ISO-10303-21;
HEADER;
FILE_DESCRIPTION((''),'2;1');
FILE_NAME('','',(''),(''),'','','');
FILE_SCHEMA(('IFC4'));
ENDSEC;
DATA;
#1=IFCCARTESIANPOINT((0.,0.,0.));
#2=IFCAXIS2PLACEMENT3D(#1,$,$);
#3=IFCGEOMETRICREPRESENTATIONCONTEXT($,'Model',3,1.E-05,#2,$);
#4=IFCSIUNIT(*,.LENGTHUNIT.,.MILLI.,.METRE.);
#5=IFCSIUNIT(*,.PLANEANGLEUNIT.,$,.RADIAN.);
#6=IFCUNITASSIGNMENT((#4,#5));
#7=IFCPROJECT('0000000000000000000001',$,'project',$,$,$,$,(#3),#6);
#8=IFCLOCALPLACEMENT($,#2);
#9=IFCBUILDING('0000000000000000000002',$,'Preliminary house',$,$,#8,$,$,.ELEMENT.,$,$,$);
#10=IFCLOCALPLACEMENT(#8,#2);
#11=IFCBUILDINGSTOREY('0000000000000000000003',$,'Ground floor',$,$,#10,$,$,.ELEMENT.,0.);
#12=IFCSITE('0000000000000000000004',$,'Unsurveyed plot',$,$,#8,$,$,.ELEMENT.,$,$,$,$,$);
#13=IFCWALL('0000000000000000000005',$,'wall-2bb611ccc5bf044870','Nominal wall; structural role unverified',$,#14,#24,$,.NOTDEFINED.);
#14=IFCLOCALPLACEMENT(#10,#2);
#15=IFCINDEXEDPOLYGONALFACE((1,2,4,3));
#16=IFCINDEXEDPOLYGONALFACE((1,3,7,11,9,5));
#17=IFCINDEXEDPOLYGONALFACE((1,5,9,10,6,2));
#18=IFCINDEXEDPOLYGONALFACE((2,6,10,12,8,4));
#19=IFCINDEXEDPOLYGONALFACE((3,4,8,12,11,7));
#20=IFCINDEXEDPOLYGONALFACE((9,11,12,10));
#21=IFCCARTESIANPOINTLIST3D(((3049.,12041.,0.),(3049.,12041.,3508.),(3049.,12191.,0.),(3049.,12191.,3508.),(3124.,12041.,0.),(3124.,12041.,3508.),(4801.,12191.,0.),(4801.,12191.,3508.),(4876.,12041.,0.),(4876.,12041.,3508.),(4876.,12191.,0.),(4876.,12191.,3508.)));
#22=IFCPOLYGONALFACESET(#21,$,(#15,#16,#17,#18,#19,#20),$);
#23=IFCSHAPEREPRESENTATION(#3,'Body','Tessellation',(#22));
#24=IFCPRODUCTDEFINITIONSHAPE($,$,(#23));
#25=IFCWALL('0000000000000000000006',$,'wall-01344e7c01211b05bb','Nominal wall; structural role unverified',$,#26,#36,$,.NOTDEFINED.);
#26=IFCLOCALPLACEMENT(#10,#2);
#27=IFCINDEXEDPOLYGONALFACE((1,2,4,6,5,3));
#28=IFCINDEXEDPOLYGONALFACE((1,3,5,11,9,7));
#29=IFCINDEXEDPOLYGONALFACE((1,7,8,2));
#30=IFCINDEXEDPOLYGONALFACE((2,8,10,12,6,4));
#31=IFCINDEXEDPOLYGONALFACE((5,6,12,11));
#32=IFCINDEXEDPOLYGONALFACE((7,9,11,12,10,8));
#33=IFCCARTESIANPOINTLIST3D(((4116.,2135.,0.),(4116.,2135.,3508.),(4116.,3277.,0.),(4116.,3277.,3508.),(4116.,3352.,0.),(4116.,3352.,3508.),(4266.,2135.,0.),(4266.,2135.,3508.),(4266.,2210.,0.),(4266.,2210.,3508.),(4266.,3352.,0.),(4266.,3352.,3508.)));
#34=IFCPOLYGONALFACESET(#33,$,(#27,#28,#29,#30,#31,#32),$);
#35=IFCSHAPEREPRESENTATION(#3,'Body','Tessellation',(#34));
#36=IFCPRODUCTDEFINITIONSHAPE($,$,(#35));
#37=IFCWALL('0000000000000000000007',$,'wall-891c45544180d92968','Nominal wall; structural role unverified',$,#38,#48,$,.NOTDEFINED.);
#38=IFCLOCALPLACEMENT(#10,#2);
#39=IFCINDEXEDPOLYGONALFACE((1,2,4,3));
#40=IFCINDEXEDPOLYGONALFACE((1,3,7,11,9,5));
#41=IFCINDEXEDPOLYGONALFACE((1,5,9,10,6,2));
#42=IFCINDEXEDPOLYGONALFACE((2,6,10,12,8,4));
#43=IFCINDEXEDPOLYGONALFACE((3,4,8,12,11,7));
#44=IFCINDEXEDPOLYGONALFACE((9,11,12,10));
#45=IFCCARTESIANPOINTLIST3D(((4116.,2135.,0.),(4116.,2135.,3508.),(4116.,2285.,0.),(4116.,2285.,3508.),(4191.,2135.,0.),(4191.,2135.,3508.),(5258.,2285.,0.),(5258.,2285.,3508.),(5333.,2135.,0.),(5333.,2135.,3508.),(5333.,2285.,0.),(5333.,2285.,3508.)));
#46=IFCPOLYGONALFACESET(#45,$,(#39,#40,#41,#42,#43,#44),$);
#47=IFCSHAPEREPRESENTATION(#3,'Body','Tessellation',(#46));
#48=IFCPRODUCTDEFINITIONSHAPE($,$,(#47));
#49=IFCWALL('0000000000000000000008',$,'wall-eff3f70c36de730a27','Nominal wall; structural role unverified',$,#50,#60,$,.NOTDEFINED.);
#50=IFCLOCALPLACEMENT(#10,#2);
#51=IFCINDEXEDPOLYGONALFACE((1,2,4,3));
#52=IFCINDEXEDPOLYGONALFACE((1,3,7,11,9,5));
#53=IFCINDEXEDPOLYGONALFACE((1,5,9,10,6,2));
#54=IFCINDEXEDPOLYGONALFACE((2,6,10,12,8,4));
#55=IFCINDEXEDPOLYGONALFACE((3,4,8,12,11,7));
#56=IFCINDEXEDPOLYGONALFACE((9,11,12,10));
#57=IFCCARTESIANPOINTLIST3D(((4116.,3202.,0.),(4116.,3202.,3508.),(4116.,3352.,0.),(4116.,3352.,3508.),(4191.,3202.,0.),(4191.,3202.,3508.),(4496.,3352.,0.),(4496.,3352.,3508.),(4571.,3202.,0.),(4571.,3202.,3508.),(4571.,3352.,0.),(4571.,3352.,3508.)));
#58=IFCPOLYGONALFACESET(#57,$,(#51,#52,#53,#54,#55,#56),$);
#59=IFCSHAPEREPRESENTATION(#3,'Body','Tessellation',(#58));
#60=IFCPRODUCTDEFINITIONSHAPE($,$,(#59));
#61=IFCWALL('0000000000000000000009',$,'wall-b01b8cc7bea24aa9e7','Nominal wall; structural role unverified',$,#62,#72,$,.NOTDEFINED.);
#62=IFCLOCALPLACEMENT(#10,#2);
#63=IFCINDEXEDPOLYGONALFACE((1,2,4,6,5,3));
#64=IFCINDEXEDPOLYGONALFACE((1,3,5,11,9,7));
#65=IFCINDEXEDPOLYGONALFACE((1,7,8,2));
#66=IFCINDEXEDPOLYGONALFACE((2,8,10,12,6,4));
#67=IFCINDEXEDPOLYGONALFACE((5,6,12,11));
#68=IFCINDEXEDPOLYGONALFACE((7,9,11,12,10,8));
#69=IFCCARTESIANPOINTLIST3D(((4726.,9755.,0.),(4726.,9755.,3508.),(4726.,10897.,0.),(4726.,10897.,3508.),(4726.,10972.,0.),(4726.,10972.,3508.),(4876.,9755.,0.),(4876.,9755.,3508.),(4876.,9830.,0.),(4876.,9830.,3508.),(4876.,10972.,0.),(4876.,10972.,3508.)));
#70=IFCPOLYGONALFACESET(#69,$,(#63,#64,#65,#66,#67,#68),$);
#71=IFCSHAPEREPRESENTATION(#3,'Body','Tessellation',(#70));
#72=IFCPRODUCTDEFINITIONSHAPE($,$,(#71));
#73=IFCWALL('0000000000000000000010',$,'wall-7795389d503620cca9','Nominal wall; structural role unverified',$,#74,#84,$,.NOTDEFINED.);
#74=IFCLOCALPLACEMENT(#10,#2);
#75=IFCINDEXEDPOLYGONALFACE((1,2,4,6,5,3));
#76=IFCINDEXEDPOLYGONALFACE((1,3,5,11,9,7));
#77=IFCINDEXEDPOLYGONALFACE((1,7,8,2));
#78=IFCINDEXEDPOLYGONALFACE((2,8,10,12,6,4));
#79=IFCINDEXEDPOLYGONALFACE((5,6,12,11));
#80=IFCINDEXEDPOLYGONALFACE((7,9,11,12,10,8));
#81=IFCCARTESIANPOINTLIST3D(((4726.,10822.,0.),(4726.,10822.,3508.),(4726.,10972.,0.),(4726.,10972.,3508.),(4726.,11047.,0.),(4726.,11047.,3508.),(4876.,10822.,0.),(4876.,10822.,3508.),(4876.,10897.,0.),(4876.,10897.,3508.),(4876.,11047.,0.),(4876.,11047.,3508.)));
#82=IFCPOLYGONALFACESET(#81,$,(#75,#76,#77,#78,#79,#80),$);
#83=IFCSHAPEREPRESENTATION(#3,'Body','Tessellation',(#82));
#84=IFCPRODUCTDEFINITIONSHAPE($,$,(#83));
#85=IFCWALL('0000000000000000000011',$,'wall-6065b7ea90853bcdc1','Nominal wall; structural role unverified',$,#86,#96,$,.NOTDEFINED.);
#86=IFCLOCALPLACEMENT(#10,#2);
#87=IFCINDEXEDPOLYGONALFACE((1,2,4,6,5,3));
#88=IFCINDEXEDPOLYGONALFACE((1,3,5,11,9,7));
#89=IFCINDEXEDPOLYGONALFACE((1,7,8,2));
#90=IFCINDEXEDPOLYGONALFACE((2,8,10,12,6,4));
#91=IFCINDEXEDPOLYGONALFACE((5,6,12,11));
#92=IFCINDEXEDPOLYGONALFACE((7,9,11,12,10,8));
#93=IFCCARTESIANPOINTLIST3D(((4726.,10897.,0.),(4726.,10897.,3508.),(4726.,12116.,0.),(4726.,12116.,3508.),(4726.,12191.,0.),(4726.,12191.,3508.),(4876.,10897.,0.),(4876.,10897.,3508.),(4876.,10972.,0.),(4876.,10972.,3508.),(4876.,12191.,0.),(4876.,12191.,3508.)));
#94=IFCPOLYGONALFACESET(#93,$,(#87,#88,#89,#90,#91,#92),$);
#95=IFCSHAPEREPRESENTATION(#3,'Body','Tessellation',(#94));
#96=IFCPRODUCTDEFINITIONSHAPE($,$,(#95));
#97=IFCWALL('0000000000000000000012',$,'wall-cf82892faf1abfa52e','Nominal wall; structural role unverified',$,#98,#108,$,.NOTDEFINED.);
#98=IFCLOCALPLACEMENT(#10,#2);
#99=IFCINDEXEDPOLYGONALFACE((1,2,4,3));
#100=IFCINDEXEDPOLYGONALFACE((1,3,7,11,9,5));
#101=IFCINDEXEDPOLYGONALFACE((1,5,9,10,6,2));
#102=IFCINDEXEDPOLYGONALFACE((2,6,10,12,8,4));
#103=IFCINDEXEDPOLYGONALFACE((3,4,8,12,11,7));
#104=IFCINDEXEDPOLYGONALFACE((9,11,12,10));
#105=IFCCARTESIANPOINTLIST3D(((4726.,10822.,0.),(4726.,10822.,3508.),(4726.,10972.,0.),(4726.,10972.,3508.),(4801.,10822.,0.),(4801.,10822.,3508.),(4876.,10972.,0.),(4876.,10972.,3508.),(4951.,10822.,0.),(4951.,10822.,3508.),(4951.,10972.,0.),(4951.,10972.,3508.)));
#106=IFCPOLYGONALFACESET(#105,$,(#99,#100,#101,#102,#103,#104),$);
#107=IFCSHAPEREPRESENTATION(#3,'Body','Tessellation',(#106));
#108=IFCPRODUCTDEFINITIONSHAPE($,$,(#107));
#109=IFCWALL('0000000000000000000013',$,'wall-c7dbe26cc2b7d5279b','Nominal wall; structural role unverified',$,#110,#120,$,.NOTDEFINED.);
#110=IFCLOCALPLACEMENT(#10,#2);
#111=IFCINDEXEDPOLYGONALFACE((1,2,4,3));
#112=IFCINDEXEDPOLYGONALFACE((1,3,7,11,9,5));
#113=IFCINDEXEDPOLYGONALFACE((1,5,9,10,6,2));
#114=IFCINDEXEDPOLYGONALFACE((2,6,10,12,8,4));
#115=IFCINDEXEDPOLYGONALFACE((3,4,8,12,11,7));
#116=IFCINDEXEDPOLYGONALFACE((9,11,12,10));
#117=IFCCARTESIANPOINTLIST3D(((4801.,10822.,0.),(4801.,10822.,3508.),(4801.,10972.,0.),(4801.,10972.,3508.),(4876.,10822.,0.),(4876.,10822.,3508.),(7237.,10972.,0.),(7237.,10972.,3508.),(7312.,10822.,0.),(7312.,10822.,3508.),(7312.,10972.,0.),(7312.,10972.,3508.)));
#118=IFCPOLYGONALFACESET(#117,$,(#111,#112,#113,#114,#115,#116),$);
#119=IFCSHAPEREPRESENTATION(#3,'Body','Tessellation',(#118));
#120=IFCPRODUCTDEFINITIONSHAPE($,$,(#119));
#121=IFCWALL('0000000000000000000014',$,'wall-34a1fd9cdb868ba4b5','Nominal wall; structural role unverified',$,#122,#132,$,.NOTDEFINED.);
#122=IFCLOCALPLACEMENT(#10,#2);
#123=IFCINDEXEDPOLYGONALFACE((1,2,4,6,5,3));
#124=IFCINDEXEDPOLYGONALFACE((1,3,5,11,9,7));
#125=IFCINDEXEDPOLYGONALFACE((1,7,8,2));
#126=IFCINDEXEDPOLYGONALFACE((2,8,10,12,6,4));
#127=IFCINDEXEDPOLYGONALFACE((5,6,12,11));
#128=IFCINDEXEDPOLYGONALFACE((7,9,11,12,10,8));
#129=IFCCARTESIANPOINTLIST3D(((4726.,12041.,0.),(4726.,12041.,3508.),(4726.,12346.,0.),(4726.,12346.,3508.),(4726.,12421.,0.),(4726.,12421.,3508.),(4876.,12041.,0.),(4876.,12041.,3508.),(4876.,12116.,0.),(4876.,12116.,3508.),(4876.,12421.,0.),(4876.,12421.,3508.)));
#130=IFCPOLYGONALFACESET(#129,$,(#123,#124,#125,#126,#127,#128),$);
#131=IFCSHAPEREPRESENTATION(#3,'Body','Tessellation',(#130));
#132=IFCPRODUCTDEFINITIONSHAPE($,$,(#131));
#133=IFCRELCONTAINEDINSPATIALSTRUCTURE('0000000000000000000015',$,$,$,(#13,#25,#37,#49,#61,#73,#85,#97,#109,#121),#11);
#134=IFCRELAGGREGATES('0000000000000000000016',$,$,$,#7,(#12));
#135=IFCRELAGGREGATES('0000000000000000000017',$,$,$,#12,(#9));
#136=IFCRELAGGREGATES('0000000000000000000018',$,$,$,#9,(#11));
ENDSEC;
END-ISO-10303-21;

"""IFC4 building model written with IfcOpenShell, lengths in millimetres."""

from ifc_helpers import new_model, si_unit, origin, place, context, project, spatial, polyline, outline, extrude, element, save


model = new_model("IFC4")

# Units and contexts
model_context = context("Model", 3, precision=1e-05, world=origin())
ifc_project = project(units=[si_unit("LENGTHUNIT", "METRE", prefix="MILLI"), si_unit("PLANEANGLEUNIT", "RADIAN")], contexts=[model_context])

# Site, building, storey
placement_1 = place(None, origin())
site = spatial("IfcSite", under=ifc_project, at=placement_1, Name="Unsurveyed plot", CompositionType="ELEMENT")
building = spatial("IfcBuilding", under=site, at=placement_1, Name="Preliminary house", CompositionType="ELEMENT")
placement_2 = place(placement_1, origin())
storey = spatial("IfcBuildingStorey", under=building, at=placement_2, Name="Ground floor", CompositionType="ELEMENT", Elevation=0.0)

# Wall
element("IfcWall", 1, at=placement_2, inside=storey, Name="wall-2bb611ccc5bf044870", Description="Nominal wall; structural role unverified", PredefinedType="NOTDEFINED", context=model_context, shape_type="SweptSolid", body=[
    extrude(outline(polyline([(4801.0, 12191.0), (4876.0, 12191.0), (4876.0, 12041.0), (3124.0, 12041.0), (3049.0, 12041.0), (3049.0, 12191.0), (4801.0, 12191.0)])), origin(), (0.0, 0.0, 1.0), 3508.0),
])

# Walls
element("IfcWall", 2, at=placement_2, inside=storey, Name="wall-01344e7c01211b05bb", Description="Nominal wall; structural role unverified", PredefinedType="NOTDEFINED", context=model_context, shape_type="SweptSolid", body=[
    extrude(outline(polyline([(4116.0, 3277.0), (4116.0, 3352.0), (4266.0, 3352.0), (4266.0, 2210.0), (4266.0, 2135.0), (4116.0, 2135.0), (4116.0, 3277.0)])), origin(), (0.0, 0.0, 1.0), 3508.0),
])
element("IfcWall", 3, at=placement_2, inside=storey, Name="wall-891c45544180d92968", Description="Nominal wall; structural role unverified", PredefinedType="NOTDEFINED", context=model_context, shape_type="SweptSolid", body=[
    extrude(outline(polyline([(5258.0, 2285.0), (5333.0, 2285.0), (5333.0, 2135.0), (4191.0, 2135.0), (4116.0, 2135.0), (4116.0, 2285.0), (5258.0, 2285.0)])), origin(), (0.0, 0.0, 1.0), 3508.0),
])
element("IfcWall", 4, at=placement_2, inside=storey, Name="wall-eff3f70c36de730a27", Description="Nominal wall; structural role unverified", PredefinedType="NOTDEFINED", context=model_context, shape_type="SweptSolid", body=[
    extrude(outline(polyline([(4496.0, 3352.0), (4571.0, 3352.0), (4571.0, 3202.0), (4191.0, 3202.0), (4116.0, 3202.0), (4116.0, 3352.0), (4496.0, 3352.0)])), origin(), (0.0, 0.0, 1.0), 3508.0),
])

# Wall
element("IfcWall", 5, at=placement_2, inside=storey, Name="wall-b01b8cc7bea24aa9e7", Description="Nominal wall; structural role unverified", PredefinedType="NOTDEFINED", context=model_context, shape_type="SweptSolid", body=[
    extrude(outline(polyline([(4726.0, 10897.0), (4726.0, 10972.0), (4876.0, 10972.0), (4876.0, 9830.0), (4876.0, 9755.0), (4726.0, 9755.0), (4726.0, 10897.0)])), origin(), (0.0, 0.0, 1.0), 3508.0),
])

# Walls
element("IfcWall", 6, at=placement_2, inside=storey, Name="wall-7795389d503620cca9", Description="Nominal wall; structural role unverified", PredefinedType="NOTDEFINED", context=model_context, shape_type="SweptSolid", body=[
    extrude(outline(polyline([(4726.0, 10972.0), (4726.0, 11047.0), (4876.0, 11047.0), (4876.0, 10897.0), (4876.0, 10822.0), (4726.0, 10822.0), (4726.0, 10972.0)])), origin(), (0.0, 0.0, 1.0), 3508.0),
])
element("IfcWall", 7, at=placement_2, inside=storey, Name="wall-6065b7ea90853bcdc1", Description="Nominal wall; structural role unverified", PredefinedType="NOTDEFINED", context=model_context, shape_type="SweptSolid", body=[
    extrude(outline(polyline([(4726.0, 12116.0), (4726.0, 12191.0), (4876.0, 12191.0), (4876.0, 10972.0), (4876.0, 10897.0), (4726.0, 10897.0), (4726.0, 12116.0)])), origin(), (0.0, 0.0, 1.0), 3508.0),
])
element("IfcWall", 8, at=placement_2, inside=storey, Name="wall-cf82892faf1abfa52e", Description="Nominal wall; structural role unverified", PredefinedType="NOTDEFINED", context=model_context, shape_type="SweptSolid", body=[
    extrude(outline(polyline([(4876.0, 10972.0), (4951.0, 10972.0), (4951.0, 10822.0), (4801.0, 10822.0), (4726.0, 10822.0), (4726.0, 10972.0), (4876.0, 10972.0)])), origin(), (0.0, 0.0, 1.0), 3508.0),
])
element("IfcWall", 9, at=placement_2, inside=storey, Name="wall-c7dbe26cc2b7d5279b", Description="Nominal wall; structural role unverified", PredefinedType="NOTDEFINED", context=model_context, shape_type="SweptSolid", body=[
    extrude(outline(polyline([(7237.0, 10972.0), (7312.0, 10972.0), (7312.0, 10822.0), (4876.0, 10822.0), (4801.0, 10822.0), (4801.0, 10972.0), (7237.0, 10972.0)])), origin(), (0.0, 0.0, 1.0), 3508.0),
])
element("IfcWall", 10, at=placement_2, inside=storey, Name="wall-34a1fd9cdb868ba4b5", Description="Nominal wall; structural role unverified", PredefinedType="NOTDEFINED", context=model_context, shape_type="SweptSolid", body=[
    extrude(outline(polyline([(4726.0, 12346.0), (4726.0, 12421.0), (4876.0, 12421.0), (4876.0, 12116.0), (4876.0, 12041.0), (4726.0, 12041.0), (4726.0, 12346.0)])), origin(), (0.0, 0.0, 1.0), 3508.0),
])

save(model, "model.ifc")
